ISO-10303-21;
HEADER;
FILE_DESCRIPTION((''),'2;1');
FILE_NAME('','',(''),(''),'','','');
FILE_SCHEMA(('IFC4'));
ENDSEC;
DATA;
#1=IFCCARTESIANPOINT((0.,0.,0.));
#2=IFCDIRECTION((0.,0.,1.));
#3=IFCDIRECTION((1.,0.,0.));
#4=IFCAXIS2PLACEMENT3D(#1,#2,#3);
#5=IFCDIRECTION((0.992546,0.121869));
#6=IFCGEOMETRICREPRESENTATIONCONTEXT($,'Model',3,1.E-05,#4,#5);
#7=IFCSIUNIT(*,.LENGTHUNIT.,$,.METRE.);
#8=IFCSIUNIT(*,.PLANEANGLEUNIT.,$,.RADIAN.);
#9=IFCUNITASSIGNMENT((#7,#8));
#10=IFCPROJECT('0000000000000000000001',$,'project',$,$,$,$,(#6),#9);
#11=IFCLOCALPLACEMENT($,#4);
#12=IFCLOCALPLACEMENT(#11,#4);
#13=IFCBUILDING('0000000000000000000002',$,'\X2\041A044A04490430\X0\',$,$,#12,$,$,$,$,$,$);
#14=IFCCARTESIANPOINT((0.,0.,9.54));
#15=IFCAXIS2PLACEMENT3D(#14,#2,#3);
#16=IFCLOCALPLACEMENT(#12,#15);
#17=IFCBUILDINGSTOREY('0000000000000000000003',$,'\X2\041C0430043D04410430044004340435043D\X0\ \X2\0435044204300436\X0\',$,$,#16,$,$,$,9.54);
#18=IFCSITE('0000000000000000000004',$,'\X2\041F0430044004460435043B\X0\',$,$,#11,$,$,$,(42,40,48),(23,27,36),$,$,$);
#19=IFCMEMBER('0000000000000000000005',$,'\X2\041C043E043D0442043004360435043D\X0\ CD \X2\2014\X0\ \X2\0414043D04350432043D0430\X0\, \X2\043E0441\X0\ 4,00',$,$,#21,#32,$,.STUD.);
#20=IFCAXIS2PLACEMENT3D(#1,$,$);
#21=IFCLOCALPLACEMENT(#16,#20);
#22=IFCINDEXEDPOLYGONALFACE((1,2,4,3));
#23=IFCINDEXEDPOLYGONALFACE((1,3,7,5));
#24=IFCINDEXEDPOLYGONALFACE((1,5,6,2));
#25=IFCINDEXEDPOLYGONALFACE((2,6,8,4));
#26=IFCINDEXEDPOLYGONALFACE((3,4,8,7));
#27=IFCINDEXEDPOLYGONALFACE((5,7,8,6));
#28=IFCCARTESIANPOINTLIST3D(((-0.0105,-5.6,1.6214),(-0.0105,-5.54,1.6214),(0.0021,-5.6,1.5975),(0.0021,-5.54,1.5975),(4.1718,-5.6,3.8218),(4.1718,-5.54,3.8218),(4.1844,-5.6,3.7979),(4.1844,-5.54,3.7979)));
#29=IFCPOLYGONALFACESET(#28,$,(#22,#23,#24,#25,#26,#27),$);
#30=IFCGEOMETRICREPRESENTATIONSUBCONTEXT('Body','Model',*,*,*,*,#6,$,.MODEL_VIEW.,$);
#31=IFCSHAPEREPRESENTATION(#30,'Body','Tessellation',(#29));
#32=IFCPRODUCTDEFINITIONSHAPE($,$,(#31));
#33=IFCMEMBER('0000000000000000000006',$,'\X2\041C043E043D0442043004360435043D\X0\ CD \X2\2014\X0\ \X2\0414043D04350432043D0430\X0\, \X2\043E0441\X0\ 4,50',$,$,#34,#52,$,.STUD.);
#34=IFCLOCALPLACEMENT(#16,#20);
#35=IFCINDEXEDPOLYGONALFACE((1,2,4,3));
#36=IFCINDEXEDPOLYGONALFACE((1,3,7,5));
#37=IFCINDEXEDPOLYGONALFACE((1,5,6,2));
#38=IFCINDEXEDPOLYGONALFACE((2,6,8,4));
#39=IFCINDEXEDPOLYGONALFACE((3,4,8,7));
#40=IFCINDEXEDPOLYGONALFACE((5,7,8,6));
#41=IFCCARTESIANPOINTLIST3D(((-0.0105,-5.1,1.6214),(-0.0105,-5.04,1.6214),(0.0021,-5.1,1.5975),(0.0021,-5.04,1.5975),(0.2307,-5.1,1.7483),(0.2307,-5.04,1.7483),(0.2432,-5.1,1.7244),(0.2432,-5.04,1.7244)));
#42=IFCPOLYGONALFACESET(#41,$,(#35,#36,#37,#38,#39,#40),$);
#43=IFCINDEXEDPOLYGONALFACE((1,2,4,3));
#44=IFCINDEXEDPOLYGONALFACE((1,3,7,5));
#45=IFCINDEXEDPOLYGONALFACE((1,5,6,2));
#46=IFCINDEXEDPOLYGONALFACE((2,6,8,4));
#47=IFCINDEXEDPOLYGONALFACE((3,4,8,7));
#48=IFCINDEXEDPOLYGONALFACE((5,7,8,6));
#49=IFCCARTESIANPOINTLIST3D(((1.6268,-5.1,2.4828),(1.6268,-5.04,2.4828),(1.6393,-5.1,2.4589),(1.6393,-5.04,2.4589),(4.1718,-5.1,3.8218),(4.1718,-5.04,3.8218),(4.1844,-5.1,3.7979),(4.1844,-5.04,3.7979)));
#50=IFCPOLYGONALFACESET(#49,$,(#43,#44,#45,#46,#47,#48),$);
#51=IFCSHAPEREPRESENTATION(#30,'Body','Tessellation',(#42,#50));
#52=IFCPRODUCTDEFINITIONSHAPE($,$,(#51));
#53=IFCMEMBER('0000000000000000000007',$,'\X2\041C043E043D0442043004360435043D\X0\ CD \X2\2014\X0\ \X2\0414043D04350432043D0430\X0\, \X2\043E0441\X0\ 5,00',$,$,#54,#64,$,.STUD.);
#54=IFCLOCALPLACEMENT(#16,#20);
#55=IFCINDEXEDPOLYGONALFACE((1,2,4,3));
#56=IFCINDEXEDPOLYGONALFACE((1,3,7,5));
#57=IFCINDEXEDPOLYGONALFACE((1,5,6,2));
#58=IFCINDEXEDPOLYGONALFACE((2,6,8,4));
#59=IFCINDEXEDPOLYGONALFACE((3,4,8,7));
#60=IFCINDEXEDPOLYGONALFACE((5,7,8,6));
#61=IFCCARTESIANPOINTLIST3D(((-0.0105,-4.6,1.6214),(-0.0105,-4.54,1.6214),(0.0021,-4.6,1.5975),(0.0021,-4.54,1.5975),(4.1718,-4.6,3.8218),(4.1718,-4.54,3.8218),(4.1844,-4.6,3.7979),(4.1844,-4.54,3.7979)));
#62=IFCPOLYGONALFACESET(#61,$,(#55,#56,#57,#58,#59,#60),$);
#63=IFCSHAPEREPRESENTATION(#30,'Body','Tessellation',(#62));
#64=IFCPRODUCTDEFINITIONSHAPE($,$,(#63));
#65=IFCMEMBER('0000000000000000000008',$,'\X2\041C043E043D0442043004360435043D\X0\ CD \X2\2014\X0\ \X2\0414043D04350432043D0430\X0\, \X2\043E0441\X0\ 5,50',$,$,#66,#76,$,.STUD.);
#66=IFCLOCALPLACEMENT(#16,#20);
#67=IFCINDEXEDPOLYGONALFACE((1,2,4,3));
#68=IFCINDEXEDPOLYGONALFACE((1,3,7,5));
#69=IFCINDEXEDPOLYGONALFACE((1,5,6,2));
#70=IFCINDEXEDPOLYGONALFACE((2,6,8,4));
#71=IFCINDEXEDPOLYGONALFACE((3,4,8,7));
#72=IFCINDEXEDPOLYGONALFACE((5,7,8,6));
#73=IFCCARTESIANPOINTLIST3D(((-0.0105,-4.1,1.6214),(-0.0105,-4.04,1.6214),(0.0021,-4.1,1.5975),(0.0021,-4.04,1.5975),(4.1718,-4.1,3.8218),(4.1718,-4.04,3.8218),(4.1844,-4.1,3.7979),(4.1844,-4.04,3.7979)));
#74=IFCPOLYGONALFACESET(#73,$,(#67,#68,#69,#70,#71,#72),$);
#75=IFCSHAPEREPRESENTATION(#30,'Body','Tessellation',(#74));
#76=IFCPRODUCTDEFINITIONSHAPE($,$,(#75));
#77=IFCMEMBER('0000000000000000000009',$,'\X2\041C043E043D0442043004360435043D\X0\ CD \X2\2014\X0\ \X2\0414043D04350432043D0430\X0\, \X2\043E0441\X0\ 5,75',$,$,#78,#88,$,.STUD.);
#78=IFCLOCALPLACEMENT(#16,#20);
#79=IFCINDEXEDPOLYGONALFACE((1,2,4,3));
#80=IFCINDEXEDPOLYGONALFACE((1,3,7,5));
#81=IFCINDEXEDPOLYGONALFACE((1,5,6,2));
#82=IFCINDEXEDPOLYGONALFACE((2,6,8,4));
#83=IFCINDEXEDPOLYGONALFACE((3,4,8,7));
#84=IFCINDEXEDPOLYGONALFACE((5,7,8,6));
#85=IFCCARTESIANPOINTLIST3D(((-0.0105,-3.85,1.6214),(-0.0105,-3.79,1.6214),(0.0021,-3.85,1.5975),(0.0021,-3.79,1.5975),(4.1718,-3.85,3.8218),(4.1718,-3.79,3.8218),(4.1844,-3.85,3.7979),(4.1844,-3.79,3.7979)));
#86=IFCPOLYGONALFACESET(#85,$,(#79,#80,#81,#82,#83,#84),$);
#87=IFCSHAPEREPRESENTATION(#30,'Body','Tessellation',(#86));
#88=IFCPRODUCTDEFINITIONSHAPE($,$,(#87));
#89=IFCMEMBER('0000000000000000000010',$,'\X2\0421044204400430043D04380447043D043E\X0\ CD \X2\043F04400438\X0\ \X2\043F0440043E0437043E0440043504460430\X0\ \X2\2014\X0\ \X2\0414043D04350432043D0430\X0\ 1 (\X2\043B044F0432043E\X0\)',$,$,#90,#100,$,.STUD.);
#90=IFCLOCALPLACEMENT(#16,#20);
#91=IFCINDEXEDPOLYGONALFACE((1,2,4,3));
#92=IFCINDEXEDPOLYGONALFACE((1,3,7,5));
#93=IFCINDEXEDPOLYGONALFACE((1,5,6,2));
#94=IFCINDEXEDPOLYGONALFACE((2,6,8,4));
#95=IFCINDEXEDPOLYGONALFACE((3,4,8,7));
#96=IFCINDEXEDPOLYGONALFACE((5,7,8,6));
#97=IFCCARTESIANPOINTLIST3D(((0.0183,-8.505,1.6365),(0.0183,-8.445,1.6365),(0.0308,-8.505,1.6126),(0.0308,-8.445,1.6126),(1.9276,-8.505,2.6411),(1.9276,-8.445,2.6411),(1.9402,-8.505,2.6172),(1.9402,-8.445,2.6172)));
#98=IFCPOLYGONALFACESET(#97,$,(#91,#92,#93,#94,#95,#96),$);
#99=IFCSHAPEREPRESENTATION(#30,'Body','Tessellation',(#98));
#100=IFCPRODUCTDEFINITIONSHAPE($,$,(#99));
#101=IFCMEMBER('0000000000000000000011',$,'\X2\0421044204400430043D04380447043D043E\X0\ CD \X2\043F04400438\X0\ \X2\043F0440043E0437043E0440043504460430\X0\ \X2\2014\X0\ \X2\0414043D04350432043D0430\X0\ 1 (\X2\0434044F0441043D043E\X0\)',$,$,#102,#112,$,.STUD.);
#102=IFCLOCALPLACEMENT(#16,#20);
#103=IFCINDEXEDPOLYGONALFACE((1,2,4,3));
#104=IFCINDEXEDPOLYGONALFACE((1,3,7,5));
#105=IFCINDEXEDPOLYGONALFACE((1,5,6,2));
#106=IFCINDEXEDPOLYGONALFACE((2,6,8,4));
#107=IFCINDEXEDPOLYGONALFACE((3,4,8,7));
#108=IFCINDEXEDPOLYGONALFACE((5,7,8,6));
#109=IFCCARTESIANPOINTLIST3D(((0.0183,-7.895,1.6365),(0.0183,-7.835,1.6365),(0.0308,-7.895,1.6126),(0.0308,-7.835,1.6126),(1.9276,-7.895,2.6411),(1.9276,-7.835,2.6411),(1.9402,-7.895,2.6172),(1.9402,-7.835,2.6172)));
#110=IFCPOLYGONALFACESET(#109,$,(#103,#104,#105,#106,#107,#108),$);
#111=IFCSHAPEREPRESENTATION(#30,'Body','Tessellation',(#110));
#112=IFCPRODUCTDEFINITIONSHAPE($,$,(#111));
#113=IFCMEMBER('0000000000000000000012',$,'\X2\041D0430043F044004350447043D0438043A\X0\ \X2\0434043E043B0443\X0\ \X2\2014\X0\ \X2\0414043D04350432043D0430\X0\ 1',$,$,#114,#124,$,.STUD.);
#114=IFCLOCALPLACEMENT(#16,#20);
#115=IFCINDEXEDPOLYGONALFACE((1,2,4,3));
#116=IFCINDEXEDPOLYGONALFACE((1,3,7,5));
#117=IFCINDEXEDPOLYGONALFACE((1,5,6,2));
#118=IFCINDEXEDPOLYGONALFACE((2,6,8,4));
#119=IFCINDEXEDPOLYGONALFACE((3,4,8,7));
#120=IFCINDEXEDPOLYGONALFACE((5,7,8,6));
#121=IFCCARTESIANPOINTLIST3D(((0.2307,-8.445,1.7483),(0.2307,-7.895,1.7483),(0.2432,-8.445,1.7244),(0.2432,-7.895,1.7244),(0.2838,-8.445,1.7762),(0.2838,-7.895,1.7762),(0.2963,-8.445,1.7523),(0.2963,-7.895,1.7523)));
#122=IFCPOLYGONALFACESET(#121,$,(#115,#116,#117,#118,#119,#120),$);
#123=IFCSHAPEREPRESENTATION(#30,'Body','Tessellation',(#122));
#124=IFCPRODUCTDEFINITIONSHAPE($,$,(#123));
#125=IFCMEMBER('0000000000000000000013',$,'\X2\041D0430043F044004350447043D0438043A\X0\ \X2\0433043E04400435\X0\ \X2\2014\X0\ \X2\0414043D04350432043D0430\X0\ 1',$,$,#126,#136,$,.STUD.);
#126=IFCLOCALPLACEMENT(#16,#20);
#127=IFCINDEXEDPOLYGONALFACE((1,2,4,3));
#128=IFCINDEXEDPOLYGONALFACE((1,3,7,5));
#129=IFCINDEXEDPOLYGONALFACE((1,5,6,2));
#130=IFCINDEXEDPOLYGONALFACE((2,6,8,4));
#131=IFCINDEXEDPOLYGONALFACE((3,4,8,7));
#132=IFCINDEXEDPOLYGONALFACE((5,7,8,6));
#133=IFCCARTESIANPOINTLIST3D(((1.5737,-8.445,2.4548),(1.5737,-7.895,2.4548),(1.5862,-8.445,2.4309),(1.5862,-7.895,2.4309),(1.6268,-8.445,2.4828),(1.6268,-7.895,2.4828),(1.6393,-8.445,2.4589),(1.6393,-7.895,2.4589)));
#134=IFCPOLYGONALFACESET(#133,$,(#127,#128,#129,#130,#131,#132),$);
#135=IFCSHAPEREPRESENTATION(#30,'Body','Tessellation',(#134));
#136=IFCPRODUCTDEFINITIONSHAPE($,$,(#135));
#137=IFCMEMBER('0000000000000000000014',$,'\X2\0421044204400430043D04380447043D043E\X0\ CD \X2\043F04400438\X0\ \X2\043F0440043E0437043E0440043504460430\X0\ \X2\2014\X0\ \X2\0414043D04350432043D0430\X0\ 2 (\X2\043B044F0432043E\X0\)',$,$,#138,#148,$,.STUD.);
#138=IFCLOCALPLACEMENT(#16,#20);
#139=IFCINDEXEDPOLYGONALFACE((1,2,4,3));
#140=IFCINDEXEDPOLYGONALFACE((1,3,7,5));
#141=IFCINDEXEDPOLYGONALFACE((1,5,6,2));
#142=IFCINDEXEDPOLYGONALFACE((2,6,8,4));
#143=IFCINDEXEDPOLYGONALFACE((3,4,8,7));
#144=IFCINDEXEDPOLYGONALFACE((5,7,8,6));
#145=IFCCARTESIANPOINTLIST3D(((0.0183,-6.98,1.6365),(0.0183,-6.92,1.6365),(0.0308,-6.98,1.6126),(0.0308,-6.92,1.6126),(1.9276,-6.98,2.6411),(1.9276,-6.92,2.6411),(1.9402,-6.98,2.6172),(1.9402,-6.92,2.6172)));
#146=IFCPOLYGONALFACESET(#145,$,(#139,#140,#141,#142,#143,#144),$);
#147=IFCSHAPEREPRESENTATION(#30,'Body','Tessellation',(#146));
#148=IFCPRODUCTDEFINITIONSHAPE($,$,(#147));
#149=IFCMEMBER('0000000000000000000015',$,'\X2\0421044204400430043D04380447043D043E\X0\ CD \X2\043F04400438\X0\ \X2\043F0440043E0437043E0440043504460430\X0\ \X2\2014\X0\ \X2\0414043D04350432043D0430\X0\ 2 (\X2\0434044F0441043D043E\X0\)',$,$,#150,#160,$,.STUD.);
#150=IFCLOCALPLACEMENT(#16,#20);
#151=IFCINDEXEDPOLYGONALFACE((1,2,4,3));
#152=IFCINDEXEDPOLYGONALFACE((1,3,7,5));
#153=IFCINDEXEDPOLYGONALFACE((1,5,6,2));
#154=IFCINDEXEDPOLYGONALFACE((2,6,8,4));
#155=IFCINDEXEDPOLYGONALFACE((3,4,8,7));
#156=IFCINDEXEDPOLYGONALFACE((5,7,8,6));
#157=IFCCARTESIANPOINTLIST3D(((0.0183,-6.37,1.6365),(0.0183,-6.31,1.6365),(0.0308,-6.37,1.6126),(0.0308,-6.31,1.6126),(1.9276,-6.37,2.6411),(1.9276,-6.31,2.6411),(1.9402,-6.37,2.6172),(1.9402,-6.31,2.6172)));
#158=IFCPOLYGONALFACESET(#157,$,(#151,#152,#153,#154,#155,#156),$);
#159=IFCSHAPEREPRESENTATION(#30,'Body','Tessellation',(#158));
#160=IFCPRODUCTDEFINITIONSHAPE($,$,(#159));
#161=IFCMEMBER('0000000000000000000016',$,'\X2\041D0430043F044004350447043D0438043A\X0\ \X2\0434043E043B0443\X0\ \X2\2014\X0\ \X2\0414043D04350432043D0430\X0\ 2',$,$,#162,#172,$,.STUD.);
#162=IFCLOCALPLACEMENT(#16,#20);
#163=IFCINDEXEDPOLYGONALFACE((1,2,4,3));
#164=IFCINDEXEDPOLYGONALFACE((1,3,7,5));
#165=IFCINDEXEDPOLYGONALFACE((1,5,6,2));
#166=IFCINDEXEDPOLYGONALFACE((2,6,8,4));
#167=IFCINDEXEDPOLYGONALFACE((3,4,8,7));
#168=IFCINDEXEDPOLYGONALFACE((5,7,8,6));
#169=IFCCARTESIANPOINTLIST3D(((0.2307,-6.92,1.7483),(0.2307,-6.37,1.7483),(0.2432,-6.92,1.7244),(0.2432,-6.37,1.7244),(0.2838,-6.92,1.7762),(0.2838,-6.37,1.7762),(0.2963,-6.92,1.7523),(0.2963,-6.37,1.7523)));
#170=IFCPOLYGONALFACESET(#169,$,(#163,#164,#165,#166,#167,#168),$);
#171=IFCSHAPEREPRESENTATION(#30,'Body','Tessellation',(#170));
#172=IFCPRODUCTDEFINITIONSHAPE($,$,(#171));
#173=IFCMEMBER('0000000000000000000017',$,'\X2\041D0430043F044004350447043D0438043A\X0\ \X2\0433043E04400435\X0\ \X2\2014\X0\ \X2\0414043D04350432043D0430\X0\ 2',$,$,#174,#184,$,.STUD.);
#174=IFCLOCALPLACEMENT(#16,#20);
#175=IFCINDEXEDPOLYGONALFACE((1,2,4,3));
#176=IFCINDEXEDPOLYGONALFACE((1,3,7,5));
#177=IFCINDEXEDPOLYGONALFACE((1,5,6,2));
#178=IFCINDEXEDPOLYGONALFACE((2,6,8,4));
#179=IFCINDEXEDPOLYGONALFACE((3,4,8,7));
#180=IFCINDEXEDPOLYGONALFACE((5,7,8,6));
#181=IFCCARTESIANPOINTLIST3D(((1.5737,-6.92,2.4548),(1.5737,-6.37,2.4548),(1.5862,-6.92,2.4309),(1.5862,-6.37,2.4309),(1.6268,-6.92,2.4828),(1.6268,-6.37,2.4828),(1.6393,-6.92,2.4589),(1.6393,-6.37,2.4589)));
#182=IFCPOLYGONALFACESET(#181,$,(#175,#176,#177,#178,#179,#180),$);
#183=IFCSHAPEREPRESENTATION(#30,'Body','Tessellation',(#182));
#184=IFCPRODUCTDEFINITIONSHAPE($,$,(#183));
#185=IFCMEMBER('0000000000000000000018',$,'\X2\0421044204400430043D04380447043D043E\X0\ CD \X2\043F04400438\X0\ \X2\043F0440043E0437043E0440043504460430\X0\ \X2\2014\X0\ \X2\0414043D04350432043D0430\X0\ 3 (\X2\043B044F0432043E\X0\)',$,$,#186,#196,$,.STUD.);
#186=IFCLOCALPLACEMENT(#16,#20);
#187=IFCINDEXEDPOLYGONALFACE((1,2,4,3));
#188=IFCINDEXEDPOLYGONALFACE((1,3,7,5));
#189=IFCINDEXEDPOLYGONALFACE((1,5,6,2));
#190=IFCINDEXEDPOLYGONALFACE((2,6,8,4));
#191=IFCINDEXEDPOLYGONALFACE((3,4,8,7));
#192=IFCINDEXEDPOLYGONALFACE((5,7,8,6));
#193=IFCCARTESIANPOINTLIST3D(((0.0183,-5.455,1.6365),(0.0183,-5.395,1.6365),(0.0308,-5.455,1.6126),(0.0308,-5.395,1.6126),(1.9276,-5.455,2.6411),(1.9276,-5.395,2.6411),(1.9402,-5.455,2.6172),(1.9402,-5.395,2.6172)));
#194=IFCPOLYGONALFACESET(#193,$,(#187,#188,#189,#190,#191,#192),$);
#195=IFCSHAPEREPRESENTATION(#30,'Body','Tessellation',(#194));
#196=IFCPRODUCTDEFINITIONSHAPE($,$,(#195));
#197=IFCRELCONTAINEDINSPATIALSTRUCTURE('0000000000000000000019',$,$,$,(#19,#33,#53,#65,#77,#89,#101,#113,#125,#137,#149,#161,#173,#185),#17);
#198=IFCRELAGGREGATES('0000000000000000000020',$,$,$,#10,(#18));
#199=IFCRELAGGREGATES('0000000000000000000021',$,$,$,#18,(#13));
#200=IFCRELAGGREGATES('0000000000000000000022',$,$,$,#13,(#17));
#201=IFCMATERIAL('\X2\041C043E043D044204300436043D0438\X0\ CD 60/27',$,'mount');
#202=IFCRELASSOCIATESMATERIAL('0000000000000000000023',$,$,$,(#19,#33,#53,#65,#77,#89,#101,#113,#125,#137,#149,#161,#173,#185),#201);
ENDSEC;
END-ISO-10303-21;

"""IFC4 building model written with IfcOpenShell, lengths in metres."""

from ifc_helpers import new_model, si_unit, direction, frame, origin_with_axes, place, context, subcontext, project, spatial, polyline, outline, extrude, material, element, save


model = new_model("IFC4")

# Units and contexts
model_context = context("Model", 3, precision=1e-05, world=origin_with_axes(), true_north=direction((0.992546, 0.121869)))
body_context = subcontext(model_context, "Body", "Model", "MODEL_VIEW")
ifc_project = project(units=[si_unit("LENGTHUNIT", "METRE"), si_unit("PLANEANGLEUNIT", "RADIAN")], contexts=[model_context])

# Site, building, storey
site_placement = place(None, origin_with_axes())
site = spatial("IfcSite", under=ifc_project, at=site_placement, Name="Парцел", RefLatitude=(42, 40, 48), RefLongitude=(23, 27, 36))
building_placement = place(site_placement, origin_with_axes())
building = spatial("IfcBuilding", under=site, at=building_placement, Name="Къща")
storey_placement = place(building_placement, frame((0.0, 0.0, 9.54), z_axis=(0.0, 0.0, 1.0), x_axis=(1.0, 0.0, 0.0)))
storey = spatial("IfcBuildingStorey", under=building, at=storey_placement, Name="Мансарден етаж", Elevation=9.54)

# Members
ifc_material_1 = material(Name="Монтажни CD 60/27", Category="mount")
member_1_placement = place(storey_placement, origin_with_axes())
element("IfcMember", 1, at=member_1_placement, inside=storey, material=ifc_material_1, Name="Монтажен CD — Дневна, ос 4,00", PredefinedType="STUD", context=body_context, shape_type="SweptSolid", body=[
    extrude(outline(polyline([(0.0021, -1.5975), (4.1844, -3.7979), (4.1718, -3.8218), (-0.0105, -1.6214), (0.0021, -1.5975)])), frame((0.0, -5.6, 0.0), z_axis=(0.0, 1.0, 0.0), x_axis=(1.0, 0.0, 0.0)), (0.0, 0.0, 1.0), 0.06),
])
member_2_placement = place(storey_placement, origin_with_axes())
element("IfcMember", 2, at=member_2_placement, inside=storey, material=ifc_material_1, Name="Монтажен CD — Дневна, ос 4,50", PredefinedType="STUD", context=body_context, shape_type="SweptSolid", body=[
    extrude(outline(polyline([(0.0021, -1.5975), (0.2432, -1.7244), (0.2307, -1.7483), (-0.0105, -1.6214), (0.0021, -1.5975)])), frame((0.0, -5.1, 0.0), z_axis=(0.0, 1.0, 0.0), x_axis=(1.0, 0.0, 0.0)), (0.0, 0.0, 1.0), 0.06),
    extrude(outline(polyline([(1.6393, -2.4589), (4.1844, -3.7979), (4.1718, -3.8218), (1.6268, -2.4828), (1.6393, -2.4589)])), frame((0.0, -5.1, 0.0), z_axis=(0.0, 1.0, 0.0), x_axis=(1.0, 0.0, 0.0)), (0.0, 0.0, 1.0), 0.06),
])
member_3_placement = place(storey_placement, origin_with_axes())
element("IfcMember", 3, at=member_3_placement, inside=storey, material=ifc_material_1, Name="Монтажен CD — Дневна, ос 5,00", PredefinedType="STUD", context=body_context, shape_type="SweptSolid", body=[
    extrude(outline(polyline([(0.0021, -1.5975), (4.1844, -3.7979), (4.1718, -3.8218), (-0.0105, -1.6214), (0.0021, -1.5975)])), frame((0.0, -4.6, 0.0), z_axis=(0.0, 1.0, 0.0), x_axis=(1.0, 0.0, 0.0)), (0.0, 0.0, 1.0), 0.06),
])
member_4_placement = place(storey_placement, origin_with_axes())
element("IfcMember", 4, at=member_4_placement, inside=storey, material=ifc_material_1, Name="Монтажен CD — Дневна, ос 5,50", PredefinedType="STUD", context=body_context, shape_type="SweptSolid", body=[
    extrude(outline(polyline([(0.0021, -1.5975), (4.1844, -3.7979), (4.1718, -3.8218), (-0.0105, -1.6214), (0.0021, -1.5975)])), frame((0.0, -4.1, 0.0), z_axis=(0.0, 1.0, 0.0), x_axis=(1.0, 0.0, 0.0)), (0.0, 0.0, 1.0), 0.06),
])
member_5_placement = place(storey_placement, origin_with_axes())
element("IfcMember", 5, at=member_5_placement, inside=storey, material=ifc_material_1, Name="Монтажен CD — Дневна, ос 5,75", PredefinedType="STUD", context=body_context, shape_type="SweptSolid", body=[
    extrude(outline(polyline([(0.0021, -1.5975), (4.1844, -3.7979), (4.1718, -3.8218), (-0.0105, -1.6214), (0.0021, -1.5975)])), frame((0.0, -3.85, 0.0), z_axis=(0.0, 1.0, 0.0), x_axis=(1.0, 0.0, 0.0)), (0.0, 0.0, 1.0), 0.06),
])
member_6_placement = place(storey_placement, origin_with_axes())
element("IfcMember", 6, at=member_6_placement, inside=storey, material=ifc_material_1, Name="Странично CD при прозореца — Дневна 1 (ляво)", PredefinedType="STUD", context=body_context, shape_type="SweptSolid", body=[
    extrude(outline(polyline([(0.0308, -1.6126), (1.9402, -2.6172), (1.9277, -2.6411), (0.0183, -1.6365), (0.0308, -1.6126)])), frame((0.0, -8.505, 0.0), z_axis=(0.0, 1.0, 0.0), x_axis=(1.0, 0.0, 0.0)), (0.0, 0.0, 1.0), 0.06),
])
member_7_placement = place(storey_placement, origin_with_axes())
element("IfcMember", 7, at=member_7_placement, inside=storey, material=ifc_material_1, Name="Странично CD при прозореца — Дневна 1 (дясно)", PredefinedType="STUD", context=body_context, shape_type="SweptSolid", body=[
    extrude(outline(polyline([(0.0308, -1.6126), (1.9402, -2.6172), (1.9277, -2.6411), (0.0183, -1.6365), (0.0308, -1.6126)])), frame((0.0, -7.895, 0.0), z_axis=(0.0, 1.0, 0.0), x_axis=(1.0, 0.0, 0.0)), (0.0, 0.0, 1.0), 0.06),
])
member_8_placement = place(storey_placement, origin_with_axes())
element("IfcMember", 8, at=member_8_placement, inside=storey, material=ifc_material_1, Name="Напречник долу — Дневна 1", PredefinedType="STUD", context=body_context, shape_type="SweptSolid", body=[
    extrude(outline(polyline([(0.2432, -1.7244), (0.2963, -1.7523), (0.2838, -1.7762), (0.2307, -1.7483), (0.2432, -1.7244)])), frame((0.0, -8.445, 0.0), z_axis=(0.0, 1.0, 0.0), x_axis=(1.0, 0.0, 0.0)), (0.0, 0.0, 1.0), 0.55),
])
member_9_placement = place(storey_placement, origin_with_axes())
element("IfcMember", 9, at=member_9_placement, inside=storey, material=ifc_material_1, Name="Напречник горе — Дневна 1", PredefinedType="STUD", context=body_context, shape_type="SweptSolid", body=[
    extrude(outline(polyline([(1.5862, -2.4309), (1.6393, -2.4589), (1.6268, -2.4828), (1.5737, -2.4548), (1.5862, -2.4309)])), frame((0.0, -8.445, 0.0), z_axis=(0.0, 1.0, 0.0), x_axis=(1.0, 0.0, 0.0)), (0.0, 0.0, 1.0), 0.55),
])
member_10_placement = place(storey_placement, origin_with_axes())
element("IfcMember", 10, at=member_10_placement, inside=storey, material=ifc_material_1, Name="Странично CD при прозореца — Дневна 2 (ляво)", PredefinedType="STUD", context=body_context, shape_type="SweptSolid", body=[
    extrude(outline(polyline([(0.0308, -1.6126), (1.9402, -2.6172), (1.9277, -2.6411), (0.0183, -1.6365), (0.0308, -1.6126)])), frame((0.0, -6.98, 0.0), z_axis=(0.0, 1.0, 0.0), x_axis=(1.0, 0.0, 0.0)), (0.0, 0.0, 1.0), 0.06),
])
member_11_placement = place(storey_placement, origin_with_axes())
element("IfcMember", 11, at=member_11_placement, inside=storey, material=ifc_material_1, Name="Странично CD при прозореца — Дневна 2 (дясно)", PredefinedType="STUD", context=body_context, shape_type="SweptSolid", body=[
    extrude(outline(polyline([(0.0308, -1.6126), (1.9402, -2.6172), (1.9277, -2.6411), (0.0183, -1.6365), (0.0308, -1.6126)])), frame((0.0, -6.37, 0.0), z_axis=(0.0, 1.0, 0.0), x_axis=(1.0, 0.0, 0.0)), (0.0, 0.0, 1.0), 0.06),
])
member_12_placement = place(storey_placement, origin_with_axes())
element("IfcMember", 12, at=member_12_placement, inside=storey, material=ifc_material_1, Name="Напречник долу — Дневна 2", PredefinedType="STUD", context=body_context, shape_type="SweptSolid", body=[
    extrude(outline(polyline([(0.2432, -1.7244), (0.2963, -1.7523), (0.2838, -1.7762), (0.2307, -1.7483), (0.2432, -1.7244)])), frame((0.0, -6.92, 0.0), z_axis=(0.0, 1.0, 0.0), x_axis=(1.0, 0.0, 0.0)), (0.0, 0.0, 1.0), 0.55),
])
member_13_placement = place(storey_placement, origin_with_axes())
element("IfcMember", 13, at=member_13_placement, inside=storey, material=ifc_material_1, Name="Напречник горе — Дневна 2", PredefinedType="STUD", context=body_context, shape_type="SweptSolid", body=[
    extrude(outline(polyline([(1.5862, -2.4309), (1.6393, -2.4589), (1.6268, -2.4828), (1.5737, -2.4548), (1.5862, -2.4309)])), frame((0.0, -6.92, 0.0), z_axis=(0.0, 1.0, 0.0), x_axis=(1.0, 0.0, 0.0)), (0.0, 0.0, 1.0), 0.55),
])
member_14_placement = place(storey_placement, origin_with_axes())
element("IfcMember", 14, at=member_14_placement, inside=storey, material=ifc_material_1, Name="Странично CD при прозореца — Дневна 3 (ляво)", PredefinedType="STUD", context=body_context, shape_type="SweptSolid", body=[
    extrude(outline(polyline([(0.0308, -1.6126), (1.9402, -2.6172), (1.9277, -2.6411), (0.0183, -1.6365), (0.0308, -1.6126)])), frame((0.0, -5.455, 0.0), z_axis=(0.0, 1.0, 0.0), x_axis=(1.0, 0.0, 0.0)), (0.0, 0.0, 1.0), 0.06),
])

save(model, "model.ifc")
